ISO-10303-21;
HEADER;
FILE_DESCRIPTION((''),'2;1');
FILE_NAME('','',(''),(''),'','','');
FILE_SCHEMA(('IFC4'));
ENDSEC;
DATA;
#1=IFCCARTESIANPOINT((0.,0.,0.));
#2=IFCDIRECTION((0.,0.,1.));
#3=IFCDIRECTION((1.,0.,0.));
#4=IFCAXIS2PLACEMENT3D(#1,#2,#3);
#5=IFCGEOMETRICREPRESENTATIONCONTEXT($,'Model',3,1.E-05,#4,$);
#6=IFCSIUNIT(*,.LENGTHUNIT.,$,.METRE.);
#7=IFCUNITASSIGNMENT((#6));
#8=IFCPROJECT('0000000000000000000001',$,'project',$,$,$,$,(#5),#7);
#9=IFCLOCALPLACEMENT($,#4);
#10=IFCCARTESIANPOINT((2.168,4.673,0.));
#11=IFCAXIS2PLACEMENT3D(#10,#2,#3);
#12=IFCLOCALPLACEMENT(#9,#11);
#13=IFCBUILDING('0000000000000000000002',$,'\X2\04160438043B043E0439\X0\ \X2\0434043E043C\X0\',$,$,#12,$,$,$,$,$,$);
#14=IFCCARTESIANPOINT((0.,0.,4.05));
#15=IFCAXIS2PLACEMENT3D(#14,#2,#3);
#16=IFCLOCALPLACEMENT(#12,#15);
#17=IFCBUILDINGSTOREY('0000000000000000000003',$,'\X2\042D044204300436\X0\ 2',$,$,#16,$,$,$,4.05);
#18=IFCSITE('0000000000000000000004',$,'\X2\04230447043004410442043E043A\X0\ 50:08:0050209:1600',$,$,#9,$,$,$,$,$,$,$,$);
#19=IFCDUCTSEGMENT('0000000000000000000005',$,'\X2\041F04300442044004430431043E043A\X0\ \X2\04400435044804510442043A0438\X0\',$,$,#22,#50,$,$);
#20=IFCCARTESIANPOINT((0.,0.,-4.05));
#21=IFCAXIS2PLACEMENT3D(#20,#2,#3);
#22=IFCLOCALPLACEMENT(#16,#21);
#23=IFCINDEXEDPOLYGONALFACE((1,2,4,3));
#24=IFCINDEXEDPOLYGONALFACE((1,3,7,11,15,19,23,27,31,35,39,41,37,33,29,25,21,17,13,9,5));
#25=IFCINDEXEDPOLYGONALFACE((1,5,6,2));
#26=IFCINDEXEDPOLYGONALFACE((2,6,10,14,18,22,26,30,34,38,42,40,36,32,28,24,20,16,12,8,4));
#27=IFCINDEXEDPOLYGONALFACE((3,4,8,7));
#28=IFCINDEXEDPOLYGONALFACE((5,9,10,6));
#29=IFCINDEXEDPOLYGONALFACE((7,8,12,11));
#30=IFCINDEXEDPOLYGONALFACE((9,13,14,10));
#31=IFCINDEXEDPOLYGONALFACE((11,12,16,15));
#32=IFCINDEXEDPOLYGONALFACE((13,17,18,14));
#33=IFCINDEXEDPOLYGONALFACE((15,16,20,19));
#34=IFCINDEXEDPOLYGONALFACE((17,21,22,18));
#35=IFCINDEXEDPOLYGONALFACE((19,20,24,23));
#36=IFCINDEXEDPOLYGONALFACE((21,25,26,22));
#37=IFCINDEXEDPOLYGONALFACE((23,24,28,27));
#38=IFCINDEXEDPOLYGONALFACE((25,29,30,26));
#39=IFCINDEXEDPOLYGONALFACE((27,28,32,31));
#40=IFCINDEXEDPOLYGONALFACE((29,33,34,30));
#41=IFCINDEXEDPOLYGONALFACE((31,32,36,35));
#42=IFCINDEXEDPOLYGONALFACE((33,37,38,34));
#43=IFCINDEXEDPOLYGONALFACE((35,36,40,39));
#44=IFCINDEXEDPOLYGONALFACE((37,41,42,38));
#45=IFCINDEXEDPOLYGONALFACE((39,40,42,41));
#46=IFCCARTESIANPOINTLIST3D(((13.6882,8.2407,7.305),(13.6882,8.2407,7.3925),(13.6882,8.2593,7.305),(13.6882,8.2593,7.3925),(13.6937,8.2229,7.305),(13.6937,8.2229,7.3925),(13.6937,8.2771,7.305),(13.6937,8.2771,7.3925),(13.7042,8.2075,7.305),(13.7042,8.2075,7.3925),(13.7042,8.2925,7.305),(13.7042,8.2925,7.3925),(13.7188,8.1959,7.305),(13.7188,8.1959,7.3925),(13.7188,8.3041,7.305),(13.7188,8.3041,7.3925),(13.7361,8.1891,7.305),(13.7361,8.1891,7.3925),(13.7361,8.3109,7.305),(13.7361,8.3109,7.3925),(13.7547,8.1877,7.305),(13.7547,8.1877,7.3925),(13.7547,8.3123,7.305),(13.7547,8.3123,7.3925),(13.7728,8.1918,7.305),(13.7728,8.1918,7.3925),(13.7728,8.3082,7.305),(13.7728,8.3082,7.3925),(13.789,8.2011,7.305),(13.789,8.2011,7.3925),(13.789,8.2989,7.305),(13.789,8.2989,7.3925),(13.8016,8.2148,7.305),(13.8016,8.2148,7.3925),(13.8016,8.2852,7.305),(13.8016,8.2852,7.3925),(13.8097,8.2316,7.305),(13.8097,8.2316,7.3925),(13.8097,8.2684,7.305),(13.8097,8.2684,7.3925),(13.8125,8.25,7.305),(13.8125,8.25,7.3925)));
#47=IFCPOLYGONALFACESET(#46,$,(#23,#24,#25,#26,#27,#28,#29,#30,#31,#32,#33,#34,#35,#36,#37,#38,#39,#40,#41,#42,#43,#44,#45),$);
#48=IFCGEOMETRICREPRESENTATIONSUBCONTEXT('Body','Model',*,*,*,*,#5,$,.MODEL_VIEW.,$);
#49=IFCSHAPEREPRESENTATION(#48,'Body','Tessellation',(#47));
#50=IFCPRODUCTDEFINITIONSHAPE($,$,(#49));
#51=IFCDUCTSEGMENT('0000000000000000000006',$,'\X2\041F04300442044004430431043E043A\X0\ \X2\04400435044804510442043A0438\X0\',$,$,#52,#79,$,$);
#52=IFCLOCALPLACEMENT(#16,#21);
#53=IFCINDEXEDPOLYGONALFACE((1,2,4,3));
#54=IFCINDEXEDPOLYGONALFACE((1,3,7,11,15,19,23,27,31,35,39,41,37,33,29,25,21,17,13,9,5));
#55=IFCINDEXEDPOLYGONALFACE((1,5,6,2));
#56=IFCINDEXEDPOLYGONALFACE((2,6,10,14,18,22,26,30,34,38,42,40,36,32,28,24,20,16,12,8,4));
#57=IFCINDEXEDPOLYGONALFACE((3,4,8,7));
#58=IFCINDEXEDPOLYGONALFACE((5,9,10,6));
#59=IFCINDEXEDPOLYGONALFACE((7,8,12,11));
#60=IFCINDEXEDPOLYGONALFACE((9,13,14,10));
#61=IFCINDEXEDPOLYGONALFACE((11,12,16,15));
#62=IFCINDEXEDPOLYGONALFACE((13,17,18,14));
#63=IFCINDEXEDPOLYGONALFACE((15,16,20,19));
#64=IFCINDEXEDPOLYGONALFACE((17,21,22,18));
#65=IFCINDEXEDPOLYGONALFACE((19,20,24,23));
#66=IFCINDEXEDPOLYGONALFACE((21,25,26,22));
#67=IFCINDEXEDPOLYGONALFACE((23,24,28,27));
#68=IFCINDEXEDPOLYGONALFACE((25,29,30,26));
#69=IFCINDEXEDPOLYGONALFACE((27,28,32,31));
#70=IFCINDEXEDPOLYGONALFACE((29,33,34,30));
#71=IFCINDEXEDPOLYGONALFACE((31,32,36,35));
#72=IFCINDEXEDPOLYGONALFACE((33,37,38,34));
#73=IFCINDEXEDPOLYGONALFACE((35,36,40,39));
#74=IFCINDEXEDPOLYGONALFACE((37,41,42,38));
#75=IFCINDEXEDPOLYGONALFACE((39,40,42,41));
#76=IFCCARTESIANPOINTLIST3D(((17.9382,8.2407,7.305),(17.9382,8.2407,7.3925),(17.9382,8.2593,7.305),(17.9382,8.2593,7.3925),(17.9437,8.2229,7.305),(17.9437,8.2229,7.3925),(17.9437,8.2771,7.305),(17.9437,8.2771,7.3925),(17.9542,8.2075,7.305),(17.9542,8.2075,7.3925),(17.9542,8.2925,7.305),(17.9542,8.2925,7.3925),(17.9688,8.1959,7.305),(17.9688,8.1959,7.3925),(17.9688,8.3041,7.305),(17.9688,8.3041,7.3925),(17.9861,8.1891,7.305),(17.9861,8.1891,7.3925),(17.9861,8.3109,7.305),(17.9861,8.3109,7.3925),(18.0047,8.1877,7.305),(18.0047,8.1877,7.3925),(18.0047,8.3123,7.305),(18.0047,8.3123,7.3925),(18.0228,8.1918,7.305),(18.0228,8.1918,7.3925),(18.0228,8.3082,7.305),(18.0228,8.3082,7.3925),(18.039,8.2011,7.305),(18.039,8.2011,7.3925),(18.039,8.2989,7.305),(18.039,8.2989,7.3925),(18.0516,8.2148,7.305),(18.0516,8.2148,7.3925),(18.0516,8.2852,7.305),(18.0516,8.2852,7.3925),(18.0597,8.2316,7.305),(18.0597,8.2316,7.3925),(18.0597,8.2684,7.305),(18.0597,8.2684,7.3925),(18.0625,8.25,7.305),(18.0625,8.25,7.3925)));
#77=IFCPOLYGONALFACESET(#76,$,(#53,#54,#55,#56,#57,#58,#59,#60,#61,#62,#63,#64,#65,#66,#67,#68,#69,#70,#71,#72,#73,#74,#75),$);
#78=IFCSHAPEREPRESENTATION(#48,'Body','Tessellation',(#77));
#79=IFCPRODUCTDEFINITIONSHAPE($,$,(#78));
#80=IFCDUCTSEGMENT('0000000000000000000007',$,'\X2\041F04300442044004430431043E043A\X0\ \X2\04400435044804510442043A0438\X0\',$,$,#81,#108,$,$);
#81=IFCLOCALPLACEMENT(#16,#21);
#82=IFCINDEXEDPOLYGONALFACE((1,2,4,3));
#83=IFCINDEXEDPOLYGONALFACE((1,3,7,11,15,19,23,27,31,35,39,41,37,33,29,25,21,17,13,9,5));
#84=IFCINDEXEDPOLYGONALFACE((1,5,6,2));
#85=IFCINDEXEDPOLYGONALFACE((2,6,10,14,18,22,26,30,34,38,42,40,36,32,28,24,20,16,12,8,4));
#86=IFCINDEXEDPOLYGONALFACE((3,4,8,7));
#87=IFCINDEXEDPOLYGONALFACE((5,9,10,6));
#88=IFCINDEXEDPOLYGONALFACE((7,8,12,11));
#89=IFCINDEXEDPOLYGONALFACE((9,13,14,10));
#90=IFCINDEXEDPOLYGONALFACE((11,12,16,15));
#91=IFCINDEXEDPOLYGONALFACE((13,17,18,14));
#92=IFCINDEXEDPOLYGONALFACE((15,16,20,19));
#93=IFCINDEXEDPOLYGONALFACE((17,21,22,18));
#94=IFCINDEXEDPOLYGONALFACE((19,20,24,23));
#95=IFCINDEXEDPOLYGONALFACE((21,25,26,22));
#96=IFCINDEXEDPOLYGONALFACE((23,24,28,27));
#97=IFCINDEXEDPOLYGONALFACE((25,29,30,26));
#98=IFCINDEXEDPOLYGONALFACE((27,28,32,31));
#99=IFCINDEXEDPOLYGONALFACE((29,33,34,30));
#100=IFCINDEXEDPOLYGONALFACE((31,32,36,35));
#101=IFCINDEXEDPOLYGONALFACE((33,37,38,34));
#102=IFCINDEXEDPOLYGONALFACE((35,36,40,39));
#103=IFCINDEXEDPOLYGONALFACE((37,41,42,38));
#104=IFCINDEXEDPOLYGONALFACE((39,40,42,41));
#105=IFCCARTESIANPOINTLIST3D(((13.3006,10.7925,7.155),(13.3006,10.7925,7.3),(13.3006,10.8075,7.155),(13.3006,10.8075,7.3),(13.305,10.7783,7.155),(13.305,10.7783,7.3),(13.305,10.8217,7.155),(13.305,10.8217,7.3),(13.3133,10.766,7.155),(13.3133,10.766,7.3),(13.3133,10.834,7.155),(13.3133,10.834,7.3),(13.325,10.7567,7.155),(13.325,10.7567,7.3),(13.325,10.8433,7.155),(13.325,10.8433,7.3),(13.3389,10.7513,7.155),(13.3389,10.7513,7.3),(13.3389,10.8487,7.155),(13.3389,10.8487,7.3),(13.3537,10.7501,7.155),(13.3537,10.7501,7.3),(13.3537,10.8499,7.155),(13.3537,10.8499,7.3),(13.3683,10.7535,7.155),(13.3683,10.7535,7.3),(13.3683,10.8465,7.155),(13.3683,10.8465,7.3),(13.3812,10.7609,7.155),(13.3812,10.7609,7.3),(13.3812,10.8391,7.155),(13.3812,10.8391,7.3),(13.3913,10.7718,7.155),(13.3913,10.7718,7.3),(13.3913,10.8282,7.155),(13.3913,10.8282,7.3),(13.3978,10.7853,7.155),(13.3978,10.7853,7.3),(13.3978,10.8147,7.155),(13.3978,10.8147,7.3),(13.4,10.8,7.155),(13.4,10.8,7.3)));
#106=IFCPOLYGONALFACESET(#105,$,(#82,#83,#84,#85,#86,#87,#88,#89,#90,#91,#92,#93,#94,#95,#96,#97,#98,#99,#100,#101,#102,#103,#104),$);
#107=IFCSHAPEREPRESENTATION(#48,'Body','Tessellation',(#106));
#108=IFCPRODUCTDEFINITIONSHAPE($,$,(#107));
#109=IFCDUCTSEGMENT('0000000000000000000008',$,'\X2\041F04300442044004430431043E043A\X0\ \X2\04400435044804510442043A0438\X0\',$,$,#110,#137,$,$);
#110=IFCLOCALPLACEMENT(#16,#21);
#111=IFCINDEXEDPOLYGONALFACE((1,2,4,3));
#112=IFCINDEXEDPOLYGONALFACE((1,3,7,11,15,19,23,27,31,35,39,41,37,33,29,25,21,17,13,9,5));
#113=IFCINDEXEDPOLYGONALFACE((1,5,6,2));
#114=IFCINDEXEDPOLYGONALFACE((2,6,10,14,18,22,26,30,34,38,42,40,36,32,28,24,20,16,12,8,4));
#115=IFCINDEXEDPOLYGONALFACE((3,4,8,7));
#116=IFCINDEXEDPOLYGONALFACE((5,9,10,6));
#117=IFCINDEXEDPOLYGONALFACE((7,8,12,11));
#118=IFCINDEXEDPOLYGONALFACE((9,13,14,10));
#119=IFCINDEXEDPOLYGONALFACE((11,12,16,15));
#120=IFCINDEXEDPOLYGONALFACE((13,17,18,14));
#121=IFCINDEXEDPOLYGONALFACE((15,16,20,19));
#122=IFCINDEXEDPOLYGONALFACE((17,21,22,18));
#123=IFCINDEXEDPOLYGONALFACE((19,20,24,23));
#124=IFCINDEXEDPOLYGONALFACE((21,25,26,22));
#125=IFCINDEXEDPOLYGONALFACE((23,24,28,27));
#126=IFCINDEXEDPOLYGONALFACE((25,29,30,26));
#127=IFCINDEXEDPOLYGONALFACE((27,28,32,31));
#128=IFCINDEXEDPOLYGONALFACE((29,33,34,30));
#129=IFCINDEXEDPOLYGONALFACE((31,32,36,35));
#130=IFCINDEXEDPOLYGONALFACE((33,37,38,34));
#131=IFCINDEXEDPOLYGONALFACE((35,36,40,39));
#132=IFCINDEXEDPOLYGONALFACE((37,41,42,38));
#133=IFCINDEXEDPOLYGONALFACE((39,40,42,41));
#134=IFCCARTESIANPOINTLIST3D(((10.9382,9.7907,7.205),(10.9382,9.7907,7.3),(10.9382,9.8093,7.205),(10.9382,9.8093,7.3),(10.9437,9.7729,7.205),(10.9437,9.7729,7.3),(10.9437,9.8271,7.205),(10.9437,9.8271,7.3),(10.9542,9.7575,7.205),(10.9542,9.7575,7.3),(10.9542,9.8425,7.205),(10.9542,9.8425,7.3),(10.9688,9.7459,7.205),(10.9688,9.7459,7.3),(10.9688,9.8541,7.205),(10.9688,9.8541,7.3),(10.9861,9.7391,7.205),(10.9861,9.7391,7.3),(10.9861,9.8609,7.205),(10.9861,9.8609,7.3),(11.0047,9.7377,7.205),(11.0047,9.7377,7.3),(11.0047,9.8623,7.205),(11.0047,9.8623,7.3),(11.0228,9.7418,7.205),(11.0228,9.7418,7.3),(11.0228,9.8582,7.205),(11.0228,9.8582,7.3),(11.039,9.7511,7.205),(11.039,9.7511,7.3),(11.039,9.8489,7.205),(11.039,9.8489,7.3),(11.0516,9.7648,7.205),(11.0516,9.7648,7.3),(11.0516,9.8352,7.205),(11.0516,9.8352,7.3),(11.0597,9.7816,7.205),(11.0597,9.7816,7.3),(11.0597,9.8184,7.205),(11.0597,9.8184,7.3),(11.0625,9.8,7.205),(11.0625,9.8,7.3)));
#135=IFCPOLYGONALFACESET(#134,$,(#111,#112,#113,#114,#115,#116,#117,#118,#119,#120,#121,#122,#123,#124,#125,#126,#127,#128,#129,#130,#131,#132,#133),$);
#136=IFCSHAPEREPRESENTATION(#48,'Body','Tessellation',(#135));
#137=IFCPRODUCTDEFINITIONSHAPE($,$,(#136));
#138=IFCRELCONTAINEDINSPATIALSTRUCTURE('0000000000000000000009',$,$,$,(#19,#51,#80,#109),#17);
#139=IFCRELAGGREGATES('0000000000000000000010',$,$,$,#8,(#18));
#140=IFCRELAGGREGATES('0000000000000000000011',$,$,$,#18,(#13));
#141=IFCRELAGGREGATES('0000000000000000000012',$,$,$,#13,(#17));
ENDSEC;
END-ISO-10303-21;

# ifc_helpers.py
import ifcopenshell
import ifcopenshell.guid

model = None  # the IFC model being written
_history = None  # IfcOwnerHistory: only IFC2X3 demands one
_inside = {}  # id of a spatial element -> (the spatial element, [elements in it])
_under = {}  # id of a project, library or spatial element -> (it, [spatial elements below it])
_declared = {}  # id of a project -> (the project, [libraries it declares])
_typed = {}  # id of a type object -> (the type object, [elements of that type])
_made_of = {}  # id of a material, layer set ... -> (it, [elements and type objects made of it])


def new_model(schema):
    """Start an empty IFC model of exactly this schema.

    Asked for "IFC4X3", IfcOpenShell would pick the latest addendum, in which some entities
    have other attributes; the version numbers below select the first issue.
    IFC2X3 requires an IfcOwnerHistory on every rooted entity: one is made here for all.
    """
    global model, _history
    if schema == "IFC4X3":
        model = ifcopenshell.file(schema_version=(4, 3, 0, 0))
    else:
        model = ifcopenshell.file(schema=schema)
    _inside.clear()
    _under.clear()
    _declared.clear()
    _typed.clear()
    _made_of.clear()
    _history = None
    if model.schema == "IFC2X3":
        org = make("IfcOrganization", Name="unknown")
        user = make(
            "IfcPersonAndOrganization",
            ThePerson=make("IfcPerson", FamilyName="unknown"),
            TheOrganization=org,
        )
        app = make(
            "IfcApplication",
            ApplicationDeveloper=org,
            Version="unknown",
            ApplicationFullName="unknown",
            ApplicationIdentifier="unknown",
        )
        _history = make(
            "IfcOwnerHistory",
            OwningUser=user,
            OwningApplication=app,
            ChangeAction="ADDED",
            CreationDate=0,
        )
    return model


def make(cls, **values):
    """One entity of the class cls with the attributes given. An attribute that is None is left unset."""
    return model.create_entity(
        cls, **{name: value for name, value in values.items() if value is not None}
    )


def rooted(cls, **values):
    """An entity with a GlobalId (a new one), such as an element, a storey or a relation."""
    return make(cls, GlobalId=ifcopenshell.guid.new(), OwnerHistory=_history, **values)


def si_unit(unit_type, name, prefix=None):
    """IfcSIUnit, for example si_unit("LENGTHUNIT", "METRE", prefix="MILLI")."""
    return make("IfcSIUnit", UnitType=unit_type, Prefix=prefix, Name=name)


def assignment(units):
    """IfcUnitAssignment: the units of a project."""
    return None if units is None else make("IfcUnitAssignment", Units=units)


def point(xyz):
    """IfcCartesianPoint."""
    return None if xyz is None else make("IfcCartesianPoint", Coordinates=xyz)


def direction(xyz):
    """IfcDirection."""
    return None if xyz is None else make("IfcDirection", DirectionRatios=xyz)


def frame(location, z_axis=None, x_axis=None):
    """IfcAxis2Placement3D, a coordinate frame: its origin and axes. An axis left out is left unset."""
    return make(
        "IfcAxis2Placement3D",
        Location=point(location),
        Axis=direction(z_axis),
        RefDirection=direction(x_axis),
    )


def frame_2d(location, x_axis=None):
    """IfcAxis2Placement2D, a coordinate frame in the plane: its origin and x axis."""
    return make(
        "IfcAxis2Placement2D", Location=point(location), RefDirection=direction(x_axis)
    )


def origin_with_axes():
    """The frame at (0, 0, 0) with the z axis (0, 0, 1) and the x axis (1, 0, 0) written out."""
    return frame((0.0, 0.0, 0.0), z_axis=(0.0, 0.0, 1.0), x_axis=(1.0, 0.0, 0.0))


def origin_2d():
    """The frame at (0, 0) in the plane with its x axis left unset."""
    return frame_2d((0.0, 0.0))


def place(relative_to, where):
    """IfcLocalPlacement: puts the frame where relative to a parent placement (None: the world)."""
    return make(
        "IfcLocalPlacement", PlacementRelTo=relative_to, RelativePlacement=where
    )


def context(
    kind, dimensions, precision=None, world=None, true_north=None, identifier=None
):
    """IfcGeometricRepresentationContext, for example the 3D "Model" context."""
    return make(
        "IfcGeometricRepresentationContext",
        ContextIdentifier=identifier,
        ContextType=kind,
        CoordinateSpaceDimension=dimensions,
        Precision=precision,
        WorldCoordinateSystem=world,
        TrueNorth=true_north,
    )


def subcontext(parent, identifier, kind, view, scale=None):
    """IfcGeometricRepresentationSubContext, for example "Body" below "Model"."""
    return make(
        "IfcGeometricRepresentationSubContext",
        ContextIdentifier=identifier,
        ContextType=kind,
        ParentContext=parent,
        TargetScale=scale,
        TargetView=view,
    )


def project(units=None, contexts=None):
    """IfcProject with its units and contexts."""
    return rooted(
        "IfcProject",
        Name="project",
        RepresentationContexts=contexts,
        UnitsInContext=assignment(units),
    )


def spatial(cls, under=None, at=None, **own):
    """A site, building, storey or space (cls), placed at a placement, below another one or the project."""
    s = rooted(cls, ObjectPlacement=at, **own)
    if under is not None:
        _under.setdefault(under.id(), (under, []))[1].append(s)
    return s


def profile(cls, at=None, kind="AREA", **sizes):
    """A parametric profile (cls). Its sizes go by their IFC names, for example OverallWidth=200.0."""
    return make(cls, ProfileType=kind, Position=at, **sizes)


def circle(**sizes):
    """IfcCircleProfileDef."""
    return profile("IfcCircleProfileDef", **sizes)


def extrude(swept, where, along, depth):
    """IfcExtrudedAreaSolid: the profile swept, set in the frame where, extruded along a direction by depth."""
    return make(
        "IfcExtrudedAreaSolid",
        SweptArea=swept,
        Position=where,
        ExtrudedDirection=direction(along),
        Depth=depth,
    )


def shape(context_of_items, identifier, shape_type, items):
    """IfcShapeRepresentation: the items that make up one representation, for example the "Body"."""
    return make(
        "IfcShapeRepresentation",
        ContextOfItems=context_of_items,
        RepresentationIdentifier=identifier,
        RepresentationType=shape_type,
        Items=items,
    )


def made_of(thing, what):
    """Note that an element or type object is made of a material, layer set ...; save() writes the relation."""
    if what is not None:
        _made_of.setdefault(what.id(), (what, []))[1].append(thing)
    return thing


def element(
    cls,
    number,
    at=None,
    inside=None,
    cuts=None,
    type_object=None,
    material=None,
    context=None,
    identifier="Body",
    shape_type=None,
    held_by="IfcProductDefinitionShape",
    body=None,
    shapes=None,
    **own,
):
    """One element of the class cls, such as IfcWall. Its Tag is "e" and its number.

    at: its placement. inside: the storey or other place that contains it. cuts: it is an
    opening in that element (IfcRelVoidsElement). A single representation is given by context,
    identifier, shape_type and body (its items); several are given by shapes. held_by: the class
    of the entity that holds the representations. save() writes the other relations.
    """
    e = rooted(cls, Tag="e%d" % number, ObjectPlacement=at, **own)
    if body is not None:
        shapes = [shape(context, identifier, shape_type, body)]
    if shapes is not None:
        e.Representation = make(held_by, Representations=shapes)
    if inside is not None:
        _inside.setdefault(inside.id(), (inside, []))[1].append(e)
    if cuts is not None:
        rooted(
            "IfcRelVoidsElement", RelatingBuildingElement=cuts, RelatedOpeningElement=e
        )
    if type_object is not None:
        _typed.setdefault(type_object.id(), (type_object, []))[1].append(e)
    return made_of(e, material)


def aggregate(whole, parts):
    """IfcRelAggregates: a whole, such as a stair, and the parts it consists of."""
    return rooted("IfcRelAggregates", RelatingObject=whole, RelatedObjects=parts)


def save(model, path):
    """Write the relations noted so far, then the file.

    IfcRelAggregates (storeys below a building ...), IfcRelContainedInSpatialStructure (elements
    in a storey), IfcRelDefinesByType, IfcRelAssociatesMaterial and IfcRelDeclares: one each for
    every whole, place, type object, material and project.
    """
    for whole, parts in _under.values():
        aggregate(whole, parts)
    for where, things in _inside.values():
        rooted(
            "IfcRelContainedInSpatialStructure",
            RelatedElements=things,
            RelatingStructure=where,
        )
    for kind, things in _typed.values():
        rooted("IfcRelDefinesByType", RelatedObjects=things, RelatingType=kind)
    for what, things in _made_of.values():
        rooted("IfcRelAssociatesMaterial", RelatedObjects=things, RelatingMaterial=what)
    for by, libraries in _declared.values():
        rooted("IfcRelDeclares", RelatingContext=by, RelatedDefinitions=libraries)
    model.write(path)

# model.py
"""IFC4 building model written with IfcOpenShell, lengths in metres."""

from ifc_helpers import new_model, si_unit, frame, origin_with_axes, origin_2d, place, context, subcontext, project, spatial, circle, extrude, element, save


model = new_model("IFC4")

# Units and contexts
model_context = context("Model", 3, precision=1e-05, world=origin_with_axes())
body_context = subcontext(model_context, "Body", "Model", "MODEL_VIEW")
ifc_project = project(units=[si_unit("LENGTHUNIT", "METRE")], contexts=[model_context])

# Site, building, storey
site_placement = place(None, origin_with_axes())
site = spatial("IfcSite", under=ifc_project, at=site_placement, Name="Участок 50:08:0050209:1600")
building_placement = place(site_placement, frame((2.168, 4.673, 0.0), z_axis=(0.0, 0.0, 1.0), x_axis=(1.0, 0.0, 0.0)))
building = spatial("IfcBuilding", under=site, at=building_placement, Name="Жилой дом")
storey_placement = place(building_placement, frame((0.0, 0.0, 4.05), z_axis=(0.0, 0.0, 1.0), x_axis=(1.0, 0.0, 0.0)))
storey = spatial("IfcBuildingStorey", under=building, at=storey_placement, Name="Этаж 2", Elevation=4.05)

# Duct segments
duct_segment_1_placement = place(storey_placement, frame((0.0, 0.0, -4.05), z_axis=(0.0, 0.0, 1.0), x_axis=(1.0, 0.0, 0.0)))
element("IfcDuctSegment", 1, at=duct_segment_1_placement, inside=storey, Name="Патрубок решётки", context=body_context, shape_type="SweptSolid", body=[
    extrude(circle(Radius=0.0625, at=origin_2d()), frame((13.75, 8.25, 7.3925), z_axis=(0.0, 0.0, -1.0), x_axis=(1.0, 0.0, 0.0)), (0.0, 0.0, 1.0), 0.0875),
])
duct_segment_2_placement = place(storey_placement, frame((0.0, 0.0, -4.05), z_axis=(0.0, 0.0, 1.0), x_axis=(1.0, 0.0, 0.0)))
element("IfcDuctSegment", 2, at=duct_segment_2_placement, inside=storey, Name="Патрубок решётки", context=body_context, shape_type="SweptSolid", body=[
    extrude(circle(Radius=0.0625, at=origin_2d()), frame((18.0, 8.25, 7.3925), z_axis=(0.0, 0.0, -1.0), x_axis=(1.0, 0.0, 0.0)), (0.0, 0.0, 1.0), 0.0875),
])
duct_segment_3_placement = place(storey_placement, frame((0.0, 0.0, -4.05), z_axis=(0.0, 0.0, 1.0), x_axis=(1.0, 0.0, 0.0)))
element("IfcDuctSegment", 3, at=duct_segment_3_placement, inside=storey, Name="Патрубок решётки", context=body_context, shape_type="SweptSolid", body=[
    extrude(circle(Radius=0.05, at=origin_2d()), frame((13.35, 10.8, 7.3), z_axis=(0.0, 0.0, -1.0), x_axis=(1.0, 0.0, 0.0)), (0.0, 0.0, 1.0), 0.145),
])
duct_segment_4_placement = place(storey_placement, frame((0.0, 0.0, -4.05), z_axis=(0.0, 0.0, 1.0), x_axis=(1.0, 0.0, 0.0)))
element("IfcDuctSegment", 4, at=duct_segment_4_placement, inside=storey, Name="Патрубок решётки", context=body_context, shape_type="SweptSolid", body=[
    extrude(circle(Radius=0.0625, at=origin_2d()), frame((11.0, 9.8, 7.3), z_axis=(0.0, 0.0, -1.0), x_axis=(1.0, 0.0, 0.0)), (0.0, 0.0, 1.0), 0.095),
])

save(model, "model.ifc")
